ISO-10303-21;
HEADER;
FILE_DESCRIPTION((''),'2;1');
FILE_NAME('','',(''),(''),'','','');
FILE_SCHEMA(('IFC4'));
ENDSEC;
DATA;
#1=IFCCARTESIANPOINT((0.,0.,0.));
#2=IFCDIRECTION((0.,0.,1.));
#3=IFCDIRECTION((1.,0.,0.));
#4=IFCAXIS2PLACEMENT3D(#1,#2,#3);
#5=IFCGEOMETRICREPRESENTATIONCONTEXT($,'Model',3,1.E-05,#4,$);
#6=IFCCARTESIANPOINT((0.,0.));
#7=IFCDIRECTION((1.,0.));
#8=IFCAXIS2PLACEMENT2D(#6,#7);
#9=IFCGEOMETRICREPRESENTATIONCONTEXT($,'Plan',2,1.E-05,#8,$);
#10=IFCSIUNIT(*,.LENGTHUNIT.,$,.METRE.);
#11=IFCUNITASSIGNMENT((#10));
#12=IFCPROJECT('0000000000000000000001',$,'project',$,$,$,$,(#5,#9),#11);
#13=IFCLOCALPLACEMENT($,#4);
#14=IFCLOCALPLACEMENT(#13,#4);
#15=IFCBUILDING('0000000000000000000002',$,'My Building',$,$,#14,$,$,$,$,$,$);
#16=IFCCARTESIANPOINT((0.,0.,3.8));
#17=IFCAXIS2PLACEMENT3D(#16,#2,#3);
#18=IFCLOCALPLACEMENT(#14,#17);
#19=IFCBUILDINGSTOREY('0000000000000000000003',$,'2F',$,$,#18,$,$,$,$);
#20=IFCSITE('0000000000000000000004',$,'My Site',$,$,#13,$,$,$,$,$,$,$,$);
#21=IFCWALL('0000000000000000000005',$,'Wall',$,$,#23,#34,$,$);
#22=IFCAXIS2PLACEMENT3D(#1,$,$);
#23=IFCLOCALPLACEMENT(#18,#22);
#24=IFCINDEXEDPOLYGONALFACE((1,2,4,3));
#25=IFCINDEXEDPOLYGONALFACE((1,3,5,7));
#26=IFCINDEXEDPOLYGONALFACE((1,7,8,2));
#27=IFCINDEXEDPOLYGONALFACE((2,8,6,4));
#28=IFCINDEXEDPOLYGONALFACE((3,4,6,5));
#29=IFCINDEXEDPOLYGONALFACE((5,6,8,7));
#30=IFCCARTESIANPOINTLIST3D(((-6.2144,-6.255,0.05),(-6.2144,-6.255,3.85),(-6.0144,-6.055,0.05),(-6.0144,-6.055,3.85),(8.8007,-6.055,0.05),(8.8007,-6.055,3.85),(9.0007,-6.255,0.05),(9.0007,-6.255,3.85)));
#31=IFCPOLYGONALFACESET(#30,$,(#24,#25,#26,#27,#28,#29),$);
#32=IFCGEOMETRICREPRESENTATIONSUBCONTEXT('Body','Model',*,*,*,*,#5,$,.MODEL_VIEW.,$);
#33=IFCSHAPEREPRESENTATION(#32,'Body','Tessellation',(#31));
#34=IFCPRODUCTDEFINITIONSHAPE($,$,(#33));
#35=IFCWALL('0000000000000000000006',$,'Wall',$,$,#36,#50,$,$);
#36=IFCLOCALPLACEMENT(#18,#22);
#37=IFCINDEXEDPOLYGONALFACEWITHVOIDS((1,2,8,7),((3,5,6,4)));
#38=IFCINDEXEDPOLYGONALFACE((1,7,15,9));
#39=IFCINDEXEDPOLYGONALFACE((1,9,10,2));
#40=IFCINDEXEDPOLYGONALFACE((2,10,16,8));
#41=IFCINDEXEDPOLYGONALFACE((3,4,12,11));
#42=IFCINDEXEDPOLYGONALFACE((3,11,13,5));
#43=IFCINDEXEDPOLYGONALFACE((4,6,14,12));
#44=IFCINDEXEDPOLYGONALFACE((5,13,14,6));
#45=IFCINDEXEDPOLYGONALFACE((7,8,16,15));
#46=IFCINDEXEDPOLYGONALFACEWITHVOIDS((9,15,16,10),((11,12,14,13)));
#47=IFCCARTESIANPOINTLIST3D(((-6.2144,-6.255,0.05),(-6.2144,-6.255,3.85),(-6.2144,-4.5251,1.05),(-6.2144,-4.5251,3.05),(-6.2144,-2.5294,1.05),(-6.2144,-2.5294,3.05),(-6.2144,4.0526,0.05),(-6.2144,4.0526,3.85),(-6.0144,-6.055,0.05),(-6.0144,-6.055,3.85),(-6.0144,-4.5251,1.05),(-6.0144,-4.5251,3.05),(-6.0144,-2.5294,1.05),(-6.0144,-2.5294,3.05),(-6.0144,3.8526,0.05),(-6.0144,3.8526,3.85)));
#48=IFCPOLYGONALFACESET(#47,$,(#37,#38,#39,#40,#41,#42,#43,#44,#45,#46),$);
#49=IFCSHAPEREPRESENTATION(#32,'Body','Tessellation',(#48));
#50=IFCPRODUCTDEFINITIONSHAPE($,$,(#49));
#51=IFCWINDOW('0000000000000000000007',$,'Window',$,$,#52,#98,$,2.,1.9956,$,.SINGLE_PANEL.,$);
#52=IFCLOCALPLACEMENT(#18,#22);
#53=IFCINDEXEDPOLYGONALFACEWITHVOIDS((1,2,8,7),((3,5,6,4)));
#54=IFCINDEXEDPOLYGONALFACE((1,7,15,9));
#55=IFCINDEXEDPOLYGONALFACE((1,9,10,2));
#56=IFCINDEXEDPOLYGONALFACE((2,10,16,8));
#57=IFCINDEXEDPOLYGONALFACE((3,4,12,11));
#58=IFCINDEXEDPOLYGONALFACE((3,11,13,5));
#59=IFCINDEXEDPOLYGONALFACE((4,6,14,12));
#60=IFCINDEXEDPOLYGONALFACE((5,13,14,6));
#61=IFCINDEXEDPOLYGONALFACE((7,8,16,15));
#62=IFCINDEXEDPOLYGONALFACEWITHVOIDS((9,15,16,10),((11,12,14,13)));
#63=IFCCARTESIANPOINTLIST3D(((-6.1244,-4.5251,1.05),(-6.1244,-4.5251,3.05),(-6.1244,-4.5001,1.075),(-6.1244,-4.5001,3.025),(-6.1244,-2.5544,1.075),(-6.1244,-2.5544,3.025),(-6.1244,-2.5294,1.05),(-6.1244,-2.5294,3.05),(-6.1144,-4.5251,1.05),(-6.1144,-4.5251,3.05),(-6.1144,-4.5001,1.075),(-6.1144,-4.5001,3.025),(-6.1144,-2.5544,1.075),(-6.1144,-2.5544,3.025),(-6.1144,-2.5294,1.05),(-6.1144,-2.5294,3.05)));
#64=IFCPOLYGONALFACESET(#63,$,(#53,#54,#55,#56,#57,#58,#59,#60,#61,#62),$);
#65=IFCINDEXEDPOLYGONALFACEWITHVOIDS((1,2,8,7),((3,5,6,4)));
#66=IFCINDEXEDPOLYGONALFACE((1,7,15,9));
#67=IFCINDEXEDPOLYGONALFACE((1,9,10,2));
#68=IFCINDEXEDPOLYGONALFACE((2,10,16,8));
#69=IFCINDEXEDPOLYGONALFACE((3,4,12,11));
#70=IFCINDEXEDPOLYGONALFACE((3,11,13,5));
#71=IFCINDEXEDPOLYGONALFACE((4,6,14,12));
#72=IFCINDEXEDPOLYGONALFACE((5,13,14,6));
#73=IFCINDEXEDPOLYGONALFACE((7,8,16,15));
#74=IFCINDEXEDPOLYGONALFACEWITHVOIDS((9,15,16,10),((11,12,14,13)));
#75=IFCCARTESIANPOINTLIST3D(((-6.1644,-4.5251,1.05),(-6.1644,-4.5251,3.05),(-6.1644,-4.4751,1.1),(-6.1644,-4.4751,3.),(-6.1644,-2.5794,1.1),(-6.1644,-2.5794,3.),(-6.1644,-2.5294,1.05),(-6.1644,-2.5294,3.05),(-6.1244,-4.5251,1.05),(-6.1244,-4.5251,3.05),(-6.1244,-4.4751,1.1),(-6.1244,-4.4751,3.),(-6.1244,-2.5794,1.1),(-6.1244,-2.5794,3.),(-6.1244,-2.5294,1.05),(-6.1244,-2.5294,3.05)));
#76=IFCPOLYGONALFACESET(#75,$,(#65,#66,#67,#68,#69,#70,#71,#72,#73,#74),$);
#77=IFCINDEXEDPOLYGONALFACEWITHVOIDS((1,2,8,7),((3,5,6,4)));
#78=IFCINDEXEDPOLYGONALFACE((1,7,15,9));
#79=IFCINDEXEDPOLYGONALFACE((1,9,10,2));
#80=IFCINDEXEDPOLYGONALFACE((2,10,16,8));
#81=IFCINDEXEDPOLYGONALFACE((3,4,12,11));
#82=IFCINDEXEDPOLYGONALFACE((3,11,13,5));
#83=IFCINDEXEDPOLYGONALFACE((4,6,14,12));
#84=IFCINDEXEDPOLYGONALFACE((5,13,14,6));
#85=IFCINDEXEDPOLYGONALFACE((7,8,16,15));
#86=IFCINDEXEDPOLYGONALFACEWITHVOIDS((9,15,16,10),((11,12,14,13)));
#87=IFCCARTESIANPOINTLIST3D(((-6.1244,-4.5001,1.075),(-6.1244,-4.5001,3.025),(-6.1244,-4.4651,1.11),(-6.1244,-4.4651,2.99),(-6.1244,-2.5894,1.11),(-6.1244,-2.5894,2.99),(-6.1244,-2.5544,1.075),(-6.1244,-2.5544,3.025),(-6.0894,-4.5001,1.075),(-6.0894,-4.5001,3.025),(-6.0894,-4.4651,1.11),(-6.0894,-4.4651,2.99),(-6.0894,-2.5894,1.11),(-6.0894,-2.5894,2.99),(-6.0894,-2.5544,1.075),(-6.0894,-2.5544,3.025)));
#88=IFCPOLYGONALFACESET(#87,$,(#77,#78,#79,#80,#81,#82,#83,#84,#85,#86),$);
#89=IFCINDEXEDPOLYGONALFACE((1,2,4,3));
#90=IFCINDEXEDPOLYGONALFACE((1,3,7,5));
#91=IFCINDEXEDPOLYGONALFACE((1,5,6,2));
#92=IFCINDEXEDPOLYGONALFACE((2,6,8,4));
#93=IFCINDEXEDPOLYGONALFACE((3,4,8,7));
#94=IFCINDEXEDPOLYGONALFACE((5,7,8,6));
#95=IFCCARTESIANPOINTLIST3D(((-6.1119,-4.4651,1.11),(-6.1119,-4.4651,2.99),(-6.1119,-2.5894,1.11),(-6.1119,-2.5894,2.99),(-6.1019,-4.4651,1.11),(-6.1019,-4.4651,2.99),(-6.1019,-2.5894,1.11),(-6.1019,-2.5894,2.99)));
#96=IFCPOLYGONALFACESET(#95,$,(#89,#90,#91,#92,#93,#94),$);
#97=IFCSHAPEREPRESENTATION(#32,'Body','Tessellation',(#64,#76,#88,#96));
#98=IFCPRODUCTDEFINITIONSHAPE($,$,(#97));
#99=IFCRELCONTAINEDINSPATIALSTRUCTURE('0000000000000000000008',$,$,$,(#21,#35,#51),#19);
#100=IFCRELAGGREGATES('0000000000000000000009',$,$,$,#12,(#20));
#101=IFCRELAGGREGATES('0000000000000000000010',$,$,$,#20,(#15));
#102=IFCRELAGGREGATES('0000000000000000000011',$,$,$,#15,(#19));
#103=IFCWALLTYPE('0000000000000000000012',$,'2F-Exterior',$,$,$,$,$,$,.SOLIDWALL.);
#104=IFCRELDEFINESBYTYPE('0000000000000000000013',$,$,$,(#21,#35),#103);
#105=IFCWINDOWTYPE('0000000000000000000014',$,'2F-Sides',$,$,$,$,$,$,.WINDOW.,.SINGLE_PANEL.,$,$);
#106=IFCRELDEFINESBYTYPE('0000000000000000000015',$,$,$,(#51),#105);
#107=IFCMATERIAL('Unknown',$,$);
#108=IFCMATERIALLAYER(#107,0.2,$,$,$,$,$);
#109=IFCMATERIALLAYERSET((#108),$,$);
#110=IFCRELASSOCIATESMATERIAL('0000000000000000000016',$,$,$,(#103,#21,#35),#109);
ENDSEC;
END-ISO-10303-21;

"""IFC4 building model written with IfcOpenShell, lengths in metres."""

from ifc_helpers import new_model, entity, si_unit, frame, origin_with_axes, origin_2d_with_axis, place, context, subcontext, project, spatial, line, indexed_curve, outline, extrude, shape, source, transform, mapped, material, layer, layer_set, layer_usage, type_object, type_shapes, element, fill, save


model = new_model("IFC4")

# Units and contexts
model_context = context("Model", 3, precision=1e-05, world=origin_with_axes())
plan_context = context("Plan", 2, precision=1e-05, world=origin_2d_with_axis())
body_context_1 = subcontext(model_context, "Body", "Model", "MODEL_VIEW")
body_context_2 = subcontext(plan_context, "Body", "Plan", "PLAN_VIEW")
ifc_project = project(units=[si_unit("LENGTHUNIT", "METRE")], contexts=[model_context, plan_context])

# Site, building, storey
site_placement = place(None, origin_with_axes())
site = spatial("IfcSite", under=ifc_project, at=site_placement, Name="My Site")
building_placement = place(site_placement, origin_with_axes())
building = spatial("IfcBuilding", under=site, at=building_placement, Name="My Building")
storey_placement = place(building_placement, frame((0.0, 0.0, 3.8), z_axis=(0.0, 0.0, 1.0), x_axis=(1.0, 0.0, 0.0)))
storey = spatial("IfcBuildingStorey", under=building, at=storey_placement, Name="2F")

# Shared definitions
ifc_material = material(Name="Unknown")

# Wall
ifc_layer_1 = layer(ifc_material, 0.2)
ifc_layer_set_1 = layer_set([ifc_layer_1])
ifc_layer_usage_1 = layer_usage(ifc_layer_set_1, "AXIS2", "POSITIVE", 0.0)
wall_type_1 = type_object("IfcWallType", Name="2F-Exterior", PredefinedType="SOLIDWALL", material=ifc_layer_set_1)
wall_1_placement = place(storey_placement, frame((-6.0144, -6.255, 0.05), z_axis=(0.0, 0.0, 1.0), x_axis=(1.0, 0.0, 0.0)))
element("IfcWall", 1, at=wall_1_placement, inside=storey, type_object=wall_type_1, material=ifc_layer_usage_1, Name="Wall", context=body_context_1, shape_type="SweptSolid", body=[
    extrude(outline(indexed_curve([(-0.2, 0.0), (0.0, 0.2), (14.8151, 0.2), (15.0151, 0.0)], segments=[line(1, 2, 3, 4, 1)])), origin_with_axes(), (0.0, 0.0, 1.0), 3.8),
])

# Wall, opening, window
ifc_layer_usage_2 = layer_usage(ifc_layer_set_1, "AXIS2", "POSITIVE", 0.0)
wall_2_placement = place(storey_placement, frame((-6.0144, -6.255, 0.05), z_axis=(0.0, 0.0, 1.0), x_axis=(0.0, 1.0, 0.0)))
wall_2 = element("IfcWall", 2, at=wall_2_placement, inside=storey, type_object=wall_type_1, material=ifc_layer_usage_2, Name="Wall", context=body_context_1, shape_type="SweptSolid", body=[
    extrude(outline(indexed_curve([(0.2, 0.0), (0.0, 0.2), (10.3077, 0.2), (10.1077, 0.0)], segments=[line(1, 2, 3, 4, 1)])), origin_with_axes(), (0.0, 0.0, 1.0), 3.8),
])
shared_shape_1 = source(origin_with_axes(), body_context_1, "Body", "SweptSolid", [
    extrude(outline(indexed_curve([(0.0, 0.0), (1.9956, 0.0), (1.9956, 2.0), (0.0, 2.0)], segments=[line(1, 2, 3, 4, 1)])), frame((0.0, -0.6, 0.0), z_axis=(0.0, -1.0, 0.0), x_axis=(1.0, 0.0, 0.0)), (0.0, 0.0, -1.0), 1.2),
])
opening_1_placement = place(wall_2_placement, frame((3.7256, 0.2, 1.0), z_axis=(0.0, 0.0, 1.0), x_axis=(-1.0, 0.0, 0.0)))
opening_1 = element("IfcOpeningElement", 3, at=opening_1_placement, cuts=wall_2, PredefinedType="OPENING", context=body_context_1, shape_type="MappedRepresentation", body=[
    mapped(shared_shape_1, transform((0.0, 0.0, 0.0), x_axis=(1.0, 0.0, 0.0), y_axis=(0.0, 1.0, 0.0), z_axis=(0.0, 0.0, 1.0), scale=1.0)),
])
window_type_1 = type_object("IfcWindowType", Name="2F-Sides", PartitioningType="SINGLE_PANEL", PredefinedType="WINDOW")
shared_shape_2 = source(origin_with_axes(), body_context_1, "Body", "SweptSolid", [
    extrude(outline(indexed_curve([(0.0, 0.0), (1.9956, 0.0), (1.9956, 2.0), (0.0, 2.0)], segments=[line(1, 2, 3, 4, 1)]), holes=[indexed_curve([(0.025, 0.025), (1.9706, 0.025), (1.9706, 1.975), (0.025, 1.975)], segments=[line(1, 2, 3, 4, 1)])]), frame((0.0, 0.09, 0.0), z_axis=(0.0, -1.0, 0.0), x_axis=(1.0, 0.0, 0.0)), (0.0, 0.0, -1.0), 0.01),
    extrude(outline(indexed_curve([(0.0, 0.0), (1.9956, 0.0), (1.9956, 2.0), (0.0, 2.0)], segments=[line(1, 2, 3, 4, 1)]), holes=[indexed_curve([(0.05, 0.05), (1.9456, 0.05), (1.9456, 1.95), (0.05, 1.95)], segments=[line(1, 2, 3, 4, 1)])]), frame((0.0, 0.05, 0.0), z_axis=(0.0, -1.0, 0.0), x_axis=(1.0, 0.0, 0.0)), (0.0, 0.0, -1.0), 0.04),
    extrude(outline(indexed_curve([(0.0, 0.0), (1.9456, 0.0), (1.9456, 1.95), (0.0, 1.95)], segments=[line(1, 2, 3, 4, 1)]), holes=[indexed_curve([(0.035, 0.035), (1.9106, 0.035), (1.9106, 1.915), (0.035, 1.915)], segments=[line(1, 2, 3, 4, 1)])]), frame((0.025, 0.09, 0.025), z_axis=(0.0, -1.0, 0.0), x_axis=(1.0, 0.0, 0.0)), (0.0, 0.0, -1.0), 0.035),
    extrude(outline(indexed_curve([(0.035, 0.035), (1.9106, 0.035), (1.9106, 1.915), (0.035, 1.915)], segments=[line(1, 2, 3, 4, 1)])), frame((0.025, 0.1025, 0.025), z_axis=(0.0, -1.0, 0.0), x_axis=(1.0, 0.0, 0.0)), (0.0, 0.0, -1.0), 0.01),
])
shared_shape_3 = source(origin_with_axes(), body_context_2, "Body", "Curve2D", [
    entity("IfcIndexedPolyCurve", entity("IfcCartesianPointList2D", [[0.05, 0.05], [1.9456, 0.05]])),
    entity("IfcIndexedPolyCurve", entity("IfcCartesianPointList2D", [[0.0, 0.1], [0.025, 0.1], [0.025, 0.09], [0.05, 0.09], [0.05, 0.05], [0.0, 0.05]]), [entity("IfcLineIndex", [1, 2, 3, 4, 5, 6, 1])]),
    entity("IfcIndexedPolyCurve", entity("IfcCartesianPointList2D", [[1.9956, 0.1], [1.9706, 0.1], [1.9706, 0.09], [1.9456, 0.09], [1.9456, 0.05], [1.9956, 0.05]]), [entity("IfcLineIndex", [1, 2, 3, 4, 5, 6, 1])]),
    entity("IfcIndexedPolyCurve", entity("IfcCartesianPointList2D", [[0.025, 0.09], [0.06, 0.09], [0.06, 0.125], [0.025, 0.125]]), [entity("IfcLineIndex", [1, 2, 3, 4, 1])]),
    entity("IfcIndexedPolyCurve", entity("IfcCartesianPointList2D", [[1.9706, 0.09], [1.9356, 0.09], [1.9356, 0.125], [1.9706, 0.125]]), [entity("IfcLineIndex", [1, 2, 3, 4, 1])]),
    entity("IfcIndexedPolyCurve", entity("IfcCartesianPointList2D", [[0.06, 0.09], [1.9356, 0.09]])),
    entity("IfcIndexedPolyCurve", entity("IfcCartesianPointList2D", [[0.06, 0.125], [1.9356, 0.125]])),
    entity("IfcIndexedPolyCurve", entity("IfcCartesianPointList2D", [[0.06, 0.1075], [1.9356, 0.1075]])),
])
type_shapes(window_type_1, [shared_shape_2, shared_shape_3])
window_1_placement = place(opening_1_placement, origin_with_axes())
window_1 = element("IfcWindow", 4, at=window_1_placement, inside=storey, type_object=window_type_1, Name="Window", OverallHeight=2.0, OverallWidth=1.9956, PartitioningType="SINGLE_PANEL", shapes=[
    shape(body_context_1, "Body", "MappedRepresentation", [mapped(shared_shape_2, transform((0.0, 0.0, 0.0), x_axis=(1.0, 0.0, 0.0), y_axis=(0.0, 1.0, 0.0), z_axis=(0.0, 0.0, 1.0), scale=1.0))]),
    shape(body_context_2, "Body", "MappedRepresentation", [mapped(shared_shape_3, transform((0.0, 0.0, 0.0), x_axis=(1.0, 0.0, 0.0), y_axis=(0.0, 1.0, 0.0), z_axis=(0.0, 0.0, 1.0), scale=1.0))]),
])
fill(opening_1, window_1)

save(model, "model.ifc")
